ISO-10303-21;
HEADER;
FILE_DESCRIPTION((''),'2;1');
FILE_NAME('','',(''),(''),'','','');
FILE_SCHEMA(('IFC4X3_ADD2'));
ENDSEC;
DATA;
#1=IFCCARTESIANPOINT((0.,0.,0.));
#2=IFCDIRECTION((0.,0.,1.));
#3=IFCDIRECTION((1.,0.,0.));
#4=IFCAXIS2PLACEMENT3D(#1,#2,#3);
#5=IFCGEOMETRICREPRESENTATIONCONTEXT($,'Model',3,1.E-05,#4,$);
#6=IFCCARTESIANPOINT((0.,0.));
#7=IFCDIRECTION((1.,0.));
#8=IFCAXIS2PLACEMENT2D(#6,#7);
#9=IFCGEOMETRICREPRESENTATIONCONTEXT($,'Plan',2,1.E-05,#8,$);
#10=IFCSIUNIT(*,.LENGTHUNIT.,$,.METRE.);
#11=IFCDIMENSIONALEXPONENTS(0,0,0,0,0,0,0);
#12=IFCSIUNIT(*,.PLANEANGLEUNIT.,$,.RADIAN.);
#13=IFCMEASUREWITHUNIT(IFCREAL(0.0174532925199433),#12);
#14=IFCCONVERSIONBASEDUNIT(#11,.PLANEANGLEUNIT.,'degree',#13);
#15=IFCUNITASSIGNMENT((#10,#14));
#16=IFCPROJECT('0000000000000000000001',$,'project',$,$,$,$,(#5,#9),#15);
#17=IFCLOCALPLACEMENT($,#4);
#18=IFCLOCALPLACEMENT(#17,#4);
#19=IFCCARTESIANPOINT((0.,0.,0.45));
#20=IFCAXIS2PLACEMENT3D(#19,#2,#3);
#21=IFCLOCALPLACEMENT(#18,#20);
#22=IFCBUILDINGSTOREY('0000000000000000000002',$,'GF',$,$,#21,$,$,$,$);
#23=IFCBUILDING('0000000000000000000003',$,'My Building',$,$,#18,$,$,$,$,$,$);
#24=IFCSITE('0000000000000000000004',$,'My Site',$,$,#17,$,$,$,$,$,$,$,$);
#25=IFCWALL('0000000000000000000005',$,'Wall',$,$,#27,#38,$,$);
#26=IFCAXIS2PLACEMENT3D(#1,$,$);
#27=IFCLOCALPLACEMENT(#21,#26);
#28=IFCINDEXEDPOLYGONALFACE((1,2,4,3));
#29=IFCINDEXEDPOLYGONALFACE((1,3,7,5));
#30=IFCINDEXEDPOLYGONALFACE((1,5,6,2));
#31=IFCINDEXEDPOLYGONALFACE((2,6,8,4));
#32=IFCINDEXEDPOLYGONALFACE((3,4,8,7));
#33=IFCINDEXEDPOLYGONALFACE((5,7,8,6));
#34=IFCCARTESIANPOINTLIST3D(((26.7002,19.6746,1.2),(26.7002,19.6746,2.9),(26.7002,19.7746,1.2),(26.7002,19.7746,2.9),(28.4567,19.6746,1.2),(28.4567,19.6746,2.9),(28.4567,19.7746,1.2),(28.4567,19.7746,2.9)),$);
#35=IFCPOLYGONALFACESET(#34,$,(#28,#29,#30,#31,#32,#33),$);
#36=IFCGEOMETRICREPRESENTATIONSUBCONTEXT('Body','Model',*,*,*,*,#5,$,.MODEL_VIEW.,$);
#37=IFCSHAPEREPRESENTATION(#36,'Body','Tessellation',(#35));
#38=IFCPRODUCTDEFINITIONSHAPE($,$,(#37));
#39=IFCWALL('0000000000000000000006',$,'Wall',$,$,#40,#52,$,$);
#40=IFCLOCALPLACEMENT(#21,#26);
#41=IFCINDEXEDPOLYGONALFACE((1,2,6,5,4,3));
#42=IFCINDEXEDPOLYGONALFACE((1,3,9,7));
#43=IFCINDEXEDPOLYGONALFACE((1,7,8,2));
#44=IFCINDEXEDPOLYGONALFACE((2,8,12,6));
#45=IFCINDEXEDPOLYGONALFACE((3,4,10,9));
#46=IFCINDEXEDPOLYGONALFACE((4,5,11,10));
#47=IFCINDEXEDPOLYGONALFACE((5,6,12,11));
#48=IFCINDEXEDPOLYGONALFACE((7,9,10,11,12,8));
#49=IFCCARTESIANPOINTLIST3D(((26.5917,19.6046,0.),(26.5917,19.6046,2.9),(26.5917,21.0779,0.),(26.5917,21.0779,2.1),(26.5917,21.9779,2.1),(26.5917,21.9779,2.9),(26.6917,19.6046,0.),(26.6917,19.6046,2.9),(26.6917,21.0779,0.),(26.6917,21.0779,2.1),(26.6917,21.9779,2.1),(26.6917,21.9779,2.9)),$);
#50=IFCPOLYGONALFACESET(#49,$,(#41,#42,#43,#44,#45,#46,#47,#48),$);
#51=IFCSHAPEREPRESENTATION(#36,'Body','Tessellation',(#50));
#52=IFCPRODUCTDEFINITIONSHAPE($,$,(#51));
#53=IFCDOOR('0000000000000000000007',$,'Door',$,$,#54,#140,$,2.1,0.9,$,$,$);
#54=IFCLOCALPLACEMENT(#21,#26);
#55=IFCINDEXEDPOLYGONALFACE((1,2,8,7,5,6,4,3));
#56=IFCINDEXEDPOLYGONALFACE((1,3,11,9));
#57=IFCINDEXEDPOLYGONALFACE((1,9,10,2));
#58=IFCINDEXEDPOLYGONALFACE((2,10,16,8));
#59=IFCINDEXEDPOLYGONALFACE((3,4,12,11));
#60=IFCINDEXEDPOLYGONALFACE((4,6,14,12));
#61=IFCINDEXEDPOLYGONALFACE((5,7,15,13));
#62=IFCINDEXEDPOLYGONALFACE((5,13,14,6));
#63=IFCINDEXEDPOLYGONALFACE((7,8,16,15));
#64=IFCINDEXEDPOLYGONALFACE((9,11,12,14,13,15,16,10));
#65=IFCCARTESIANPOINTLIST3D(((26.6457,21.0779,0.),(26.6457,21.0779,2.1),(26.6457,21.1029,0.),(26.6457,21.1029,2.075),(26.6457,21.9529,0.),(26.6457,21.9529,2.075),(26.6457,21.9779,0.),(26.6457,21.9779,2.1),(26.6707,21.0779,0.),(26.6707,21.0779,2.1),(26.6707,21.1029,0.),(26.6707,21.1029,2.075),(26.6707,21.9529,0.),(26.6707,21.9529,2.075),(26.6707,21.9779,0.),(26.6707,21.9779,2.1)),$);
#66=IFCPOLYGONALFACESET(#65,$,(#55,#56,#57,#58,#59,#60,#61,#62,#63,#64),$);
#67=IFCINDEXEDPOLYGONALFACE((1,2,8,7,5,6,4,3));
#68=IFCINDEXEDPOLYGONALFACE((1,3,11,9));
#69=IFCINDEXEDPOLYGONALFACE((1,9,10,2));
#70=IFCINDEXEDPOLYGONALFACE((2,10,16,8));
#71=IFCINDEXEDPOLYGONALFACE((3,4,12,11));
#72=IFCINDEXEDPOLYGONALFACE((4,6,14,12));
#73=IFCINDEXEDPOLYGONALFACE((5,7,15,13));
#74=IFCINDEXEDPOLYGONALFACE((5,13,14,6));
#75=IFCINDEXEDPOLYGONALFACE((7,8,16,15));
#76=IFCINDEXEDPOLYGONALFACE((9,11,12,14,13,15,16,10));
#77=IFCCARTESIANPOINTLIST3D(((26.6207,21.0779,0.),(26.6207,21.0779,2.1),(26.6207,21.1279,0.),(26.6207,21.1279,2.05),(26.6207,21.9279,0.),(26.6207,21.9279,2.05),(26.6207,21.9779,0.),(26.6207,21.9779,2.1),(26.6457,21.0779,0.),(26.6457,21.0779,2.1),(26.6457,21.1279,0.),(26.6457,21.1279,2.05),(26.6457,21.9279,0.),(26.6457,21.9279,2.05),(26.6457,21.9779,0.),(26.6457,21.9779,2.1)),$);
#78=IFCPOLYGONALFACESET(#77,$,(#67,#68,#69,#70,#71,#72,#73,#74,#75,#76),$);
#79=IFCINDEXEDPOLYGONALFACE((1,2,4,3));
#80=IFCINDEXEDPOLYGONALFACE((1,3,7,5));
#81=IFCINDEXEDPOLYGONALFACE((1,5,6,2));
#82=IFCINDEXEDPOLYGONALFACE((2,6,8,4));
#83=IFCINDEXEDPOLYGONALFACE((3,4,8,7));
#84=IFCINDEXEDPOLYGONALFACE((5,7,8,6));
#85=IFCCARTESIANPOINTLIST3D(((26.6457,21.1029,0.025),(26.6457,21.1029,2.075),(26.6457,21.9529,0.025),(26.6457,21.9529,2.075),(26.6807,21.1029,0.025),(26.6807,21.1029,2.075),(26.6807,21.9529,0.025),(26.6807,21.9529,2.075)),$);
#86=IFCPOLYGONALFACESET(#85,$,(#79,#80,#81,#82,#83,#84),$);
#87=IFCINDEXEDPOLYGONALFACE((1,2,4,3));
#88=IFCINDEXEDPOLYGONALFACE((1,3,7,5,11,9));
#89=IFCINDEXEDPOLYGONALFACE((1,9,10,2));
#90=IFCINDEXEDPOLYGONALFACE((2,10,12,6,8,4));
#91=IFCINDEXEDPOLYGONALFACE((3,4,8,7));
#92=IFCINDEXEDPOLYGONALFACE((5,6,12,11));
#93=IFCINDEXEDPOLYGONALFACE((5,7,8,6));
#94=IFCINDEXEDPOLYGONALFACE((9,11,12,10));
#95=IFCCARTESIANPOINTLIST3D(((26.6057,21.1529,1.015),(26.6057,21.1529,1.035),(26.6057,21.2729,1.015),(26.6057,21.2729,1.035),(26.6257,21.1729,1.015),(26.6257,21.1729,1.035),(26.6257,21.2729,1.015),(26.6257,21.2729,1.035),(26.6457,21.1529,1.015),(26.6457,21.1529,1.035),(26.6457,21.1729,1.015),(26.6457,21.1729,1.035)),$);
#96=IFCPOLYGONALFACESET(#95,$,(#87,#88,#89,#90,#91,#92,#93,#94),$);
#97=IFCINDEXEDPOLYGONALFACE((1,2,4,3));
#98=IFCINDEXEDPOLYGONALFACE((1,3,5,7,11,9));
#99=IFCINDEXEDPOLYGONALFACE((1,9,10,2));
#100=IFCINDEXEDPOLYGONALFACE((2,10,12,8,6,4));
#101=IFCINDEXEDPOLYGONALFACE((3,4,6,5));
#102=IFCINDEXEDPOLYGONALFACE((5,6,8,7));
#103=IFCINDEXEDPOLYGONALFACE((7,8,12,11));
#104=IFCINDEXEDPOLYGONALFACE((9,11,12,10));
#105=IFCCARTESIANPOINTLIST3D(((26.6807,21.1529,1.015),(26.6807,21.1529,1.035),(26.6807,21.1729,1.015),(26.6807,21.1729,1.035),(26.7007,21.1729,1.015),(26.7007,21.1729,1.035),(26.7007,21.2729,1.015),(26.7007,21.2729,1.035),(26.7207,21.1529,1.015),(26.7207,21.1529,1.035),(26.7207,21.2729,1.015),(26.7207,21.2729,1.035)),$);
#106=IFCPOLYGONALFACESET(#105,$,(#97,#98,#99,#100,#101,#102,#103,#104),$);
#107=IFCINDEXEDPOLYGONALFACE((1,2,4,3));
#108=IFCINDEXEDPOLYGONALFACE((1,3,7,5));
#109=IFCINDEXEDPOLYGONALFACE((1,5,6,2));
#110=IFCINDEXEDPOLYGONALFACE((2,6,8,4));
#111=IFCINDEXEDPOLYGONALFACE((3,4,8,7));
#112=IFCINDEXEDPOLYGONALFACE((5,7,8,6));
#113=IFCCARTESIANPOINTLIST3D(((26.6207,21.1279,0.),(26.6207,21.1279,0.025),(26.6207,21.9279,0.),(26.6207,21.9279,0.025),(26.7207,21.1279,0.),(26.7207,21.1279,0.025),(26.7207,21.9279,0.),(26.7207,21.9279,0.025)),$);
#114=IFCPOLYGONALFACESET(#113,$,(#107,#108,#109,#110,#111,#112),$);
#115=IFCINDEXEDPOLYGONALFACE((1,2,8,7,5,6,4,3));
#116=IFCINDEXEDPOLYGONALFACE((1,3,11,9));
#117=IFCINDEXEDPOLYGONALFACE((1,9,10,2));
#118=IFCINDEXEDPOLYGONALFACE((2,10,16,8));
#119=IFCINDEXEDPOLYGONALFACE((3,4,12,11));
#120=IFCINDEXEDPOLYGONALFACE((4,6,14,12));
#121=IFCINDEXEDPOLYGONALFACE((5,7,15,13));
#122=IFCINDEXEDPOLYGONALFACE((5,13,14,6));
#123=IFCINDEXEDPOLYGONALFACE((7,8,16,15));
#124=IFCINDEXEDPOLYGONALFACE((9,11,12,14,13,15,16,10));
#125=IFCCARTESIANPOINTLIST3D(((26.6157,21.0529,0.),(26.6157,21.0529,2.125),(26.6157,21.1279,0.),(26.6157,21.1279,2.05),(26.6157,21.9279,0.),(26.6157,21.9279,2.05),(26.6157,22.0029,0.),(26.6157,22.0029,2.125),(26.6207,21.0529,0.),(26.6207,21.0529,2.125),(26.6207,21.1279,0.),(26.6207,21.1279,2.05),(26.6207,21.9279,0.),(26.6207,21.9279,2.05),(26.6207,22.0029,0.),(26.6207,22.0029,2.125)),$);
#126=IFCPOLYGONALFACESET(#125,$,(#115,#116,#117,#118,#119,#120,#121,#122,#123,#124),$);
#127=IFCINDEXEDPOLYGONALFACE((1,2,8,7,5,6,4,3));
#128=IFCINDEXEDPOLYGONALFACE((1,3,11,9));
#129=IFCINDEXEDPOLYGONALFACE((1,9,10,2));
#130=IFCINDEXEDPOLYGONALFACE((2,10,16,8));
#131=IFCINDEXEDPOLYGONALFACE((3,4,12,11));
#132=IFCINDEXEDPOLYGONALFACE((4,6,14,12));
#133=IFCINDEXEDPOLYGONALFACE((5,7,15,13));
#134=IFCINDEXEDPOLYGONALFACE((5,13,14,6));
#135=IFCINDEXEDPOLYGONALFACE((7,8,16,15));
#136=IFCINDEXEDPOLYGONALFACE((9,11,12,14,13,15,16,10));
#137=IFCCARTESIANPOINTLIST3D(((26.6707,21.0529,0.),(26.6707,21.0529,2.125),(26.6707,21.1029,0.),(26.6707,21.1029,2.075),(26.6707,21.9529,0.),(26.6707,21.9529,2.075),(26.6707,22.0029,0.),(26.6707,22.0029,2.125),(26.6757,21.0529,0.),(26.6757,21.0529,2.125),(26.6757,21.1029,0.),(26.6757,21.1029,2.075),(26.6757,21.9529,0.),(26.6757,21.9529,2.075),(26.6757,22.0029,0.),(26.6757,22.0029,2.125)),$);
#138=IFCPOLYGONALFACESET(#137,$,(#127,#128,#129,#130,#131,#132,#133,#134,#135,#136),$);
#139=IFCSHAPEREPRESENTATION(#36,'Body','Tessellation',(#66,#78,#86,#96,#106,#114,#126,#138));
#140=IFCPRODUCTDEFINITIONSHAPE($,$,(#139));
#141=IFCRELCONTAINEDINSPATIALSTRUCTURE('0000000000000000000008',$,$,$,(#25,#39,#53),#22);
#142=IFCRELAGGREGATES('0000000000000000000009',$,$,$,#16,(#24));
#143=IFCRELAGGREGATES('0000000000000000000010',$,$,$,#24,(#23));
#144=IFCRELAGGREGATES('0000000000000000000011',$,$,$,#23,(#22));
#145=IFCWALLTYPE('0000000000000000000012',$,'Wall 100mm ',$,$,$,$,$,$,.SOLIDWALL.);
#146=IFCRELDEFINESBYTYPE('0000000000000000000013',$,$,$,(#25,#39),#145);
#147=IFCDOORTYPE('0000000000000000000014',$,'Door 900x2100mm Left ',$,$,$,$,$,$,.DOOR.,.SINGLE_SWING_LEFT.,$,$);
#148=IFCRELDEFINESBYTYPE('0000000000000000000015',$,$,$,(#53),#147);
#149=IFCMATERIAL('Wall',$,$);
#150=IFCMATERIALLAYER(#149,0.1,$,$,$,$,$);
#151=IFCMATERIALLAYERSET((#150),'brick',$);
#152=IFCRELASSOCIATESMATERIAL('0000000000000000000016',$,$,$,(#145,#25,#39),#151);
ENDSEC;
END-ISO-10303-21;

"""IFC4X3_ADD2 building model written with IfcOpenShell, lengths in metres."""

from ifc_helpers import new_model, entity, si_unit, converted_unit, frame, origin_with_axes, origin_2d_with_axis, place, context, subcontext, project, spatial, line, indexed_curve, outline, extrude, shape, source, transform, mapped, material, layer, layer_set, layer_usage, type_object, type_shapes, element, fill, save


model = new_model("IFC4X3_ADD2")

# Units and contexts
model_context = context("Model", 3, precision=1e-05, world=origin_with_axes())
plan_context = context("Plan", 2, precision=1e-05, world=origin_2d_with_axis())
body_context_1 = subcontext(model_context, "Body", "Model", "MODEL_VIEW")
body_context_2 = subcontext(plan_context, "Body", "Plan", "PLAN_VIEW")
ifc_project = project(units=[si_unit("LENGTHUNIT", "METRE"), converted_unit("PLANEANGLEUNIT", "degree", entity("IfcReal", 0.0174532925199433), si_unit("PLANEANGLEUNIT", "RADIAN"), dimensions=[0, 0, 0, 0, 0, 0, 0])], contexts=[model_context, plan_context])

# Site, building, storey
site_placement = place(None, origin_with_axes())
site = spatial("IfcSite", under=ifc_project, at=site_placement, Name="My Site")
building_placement = place(site_placement, origin_with_axes())
building = spatial("IfcBuilding", under=site, at=building_placement, Name="My Building")
storey_placement = place(building_placement, frame((0.0, 0.0, 0.45), z_axis=(0.0, 0.0, 1.0), x_axis=(1.0, 0.0, 0.0)))
storey = spatial("IfcBuildingStorey", under=building, at=storey_placement, Name="GF")

# Shared definitions
ifc_material_1 = material(Name="Wall")

# Shared definitions
ifc_layer_1 = layer(ifc_material_1, 0.1)
ifc_layer_set_1 = layer_set([ifc_layer_1], Name="brick")
wall_type_1 = type_object("IfcWallType", Name="Wall 100mm ", PredefinedType="SOLIDWALL", material=ifc_layer_set_1)

# Wall
ifc_layer_usage_1 = layer_usage(ifc_layer_set_1, "AXIS2", "POSITIVE", 0.0)
wall_1_placement = place(storey_placement, frame((26.7002, 19.6746, 1.2), z_axis=(0.0, 0.0, 1.0), x_axis=(1.0, 0.0, 0.0)))
element("IfcWall", 1, at=wall_1_placement, inside=storey, type_object=wall_type_1, material=ifc_layer_usage_1, Name="Wall", context=body_context_1, shape_type="SweptSolid", body=[
    extrude(outline(indexed_curve([(0.0, 0.0), (0.0, 0.1), (1.7565, 0.1), (1.7565, 0.0), (0.0, 0.0)], self_intersect=False)), origin_with_axes(), (0.0, 0.0, 1.0), 1.7),
])

# Wall, opening, door
ifc_layer_usage_2 = layer_usage(ifc_layer_set_1, "AXIS2", "POSITIVE", 0.0)
wall_2_placement = place(storey_placement, frame((26.6917, 19.6046, 0.0), z_axis=(0.0, 0.0, 1.0), x_axis=(0.0, 1.0, 0.0)))
wall_2 = element("IfcWall", 2, at=wall_2_placement, inside=storey, type_object=wall_type_1, material=ifc_layer_usage_2, Name="Wall", context=body_context_1, shape_type="SweptSolid", body=[
    extrude(outline(indexed_curve([(0.0, 0.0), (0.0, 0.1), (2.3733, 0.1), (2.3733, 0.0), (0.0, 0.0)], self_intersect=False)), origin_with_axes(), (0.0, 0.0, 1.0), 2.9),
])
shared_shape_1 = source(origin_with_axes(), body_context_1, "Body", "SweptSolid", [
    extrude(outline(indexed_curve([(0.0, 0.0), (0.9, 0.0), (0.9, 2.1), (0.0, 2.1)], segments=[line(1, 2, 3, 4, 1)])), frame((0.0, -0.6, 0.0), z_axis=(0.0, -1.0, 0.0), x_axis=(1.0, 0.0, 0.0)), (0.0, 0.0, -1.0), 1.2),
])
opening_1_placement = place(wall_2_placement, frame((2.3733, 0.071, 0.0), z_axis=(0.0, 0.0, 1.0), x_axis=(-1.0, 0.0, 0.0)))
opening_1 = element("IfcOpeningElement", 3, at=opening_1_placement, cuts=wall_2, PredefinedType="OPENING", context=body_context_1, shape_type="MappedRepresentation", body=[
    mapped(shared_shape_1, transform((0.0, 0.0, 0.0), x_axis=(1.0, 0.0, 0.0), y_axis=(0.0, 1.0, 0.0), z_axis=(0.0, 0.0, 1.0), scale=1.0)),
])
door_type_1 = type_object("IfcDoorType", Name="Door 900x2100mm Left ", OperationType="SINGLE_SWING_LEFT", PredefinedType="DOOR")
shared_shape_2 = source(origin_with_axes(), body_context_1, "Body", "SweptSolid", [
    extrude(outline(indexed_curve([(0.0, 0.0), (0.0, 2.1), (0.9, 2.1), (0.9, 0.0), (0.875, 0.0), (0.875, 2.075), (0.025, 2.075), (0.025, 0.0)], segments=[line(1, 2, 3, 4, 5, 6, 7, 8, 1)])), frame((0.0, 0.025, 0.0), z_axis=(0.0, -1.0, 0.0), x_axis=(1.0, 0.0, 0.0)), (0.0, 0.0, -1.0), 0.025),
    extrude(outline(indexed_curve([(0.0, 0.0), (0.0, 2.1), (0.9, 2.1), (0.9, 0.0), (0.85, 0.0), (0.85, 2.05), (0.05, 2.05), (0.05, 0.0)], segments=[line(1, 2, 3, 4, 5, 6, 7, 8, 1)])), frame((0.0, 0.0, 0.0), z_axis=(0.0, -1.0, 0.0), x_axis=(1.0, 0.0, 0.0)), (0.0, 0.0, -1.0), 0.025),
    extrude(outline(indexed_curve([(0.0, 0.0), (0.85, 0.0), (0.85, 0.035), (0.0, 0.035)], segments=[line(1, 2, 3, 4, 1)])), frame((0.025, 0.025, 0.025), z_axis=(0.0, 0.0, 1.0), x_axis=(1.0, 0.0, 0.0)), (0.0, 0.0, 1.0), 2.05),
    extrude(outline(indexed_curve([(0.0, 0.0), (0.0, -0.04), (-0.12, -0.04), (-0.12, -0.02), (-0.02, -0.02), (-0.02, 0.0)], segments=[line(1, 2, 3, 4, 5, 6, 1)])), frame((0.825, 0.025, 1.015), z_axis=(0.0, 0.0, 1.0), x_axis=(1.0, 0.0, 0.0)), (0.0, 0.0, 1.0), 0.02),
    extrude(outline(indexed_curve([(0.0, 0.0), (0.0, 0.04), (-0.12, 0.04), (-0.12, 0.02), (-0.02, 0.02), (-0.02, 0.0)], segments=[line(1, 2, 3, 4, 5, 6, 1)])), frame((0.825, 0.06, 1.015), z_axis=(0.0, 0.0, 1.0), x_axis=(1.0, 0.0, 0.0)), (0.0, 0.0, 1.0), 0.02),
    extrude(outline(indexed_curve([(0.0, 0.0), (0.8, 0.0), (0.8, 0.1), (0.0, 0.1)], segments=[line(1, 2, 3, 4, 1)])), frame((0.05, 0.0, 0.0), z_axis=(0.0, 0.0, 1.0), x_axis=(1.0, 0.0, 0.0)), (0.0, 0.0, 1.0), 0.025),
    extrude(outline(indexed_curve([(0.0, 0.0), (0.0, 2.125), (0.95, 2.125), (0.95, 0.0), (0.875, 0.0), (0.875, 2.05), (0.075, 2.05), (0.075, 0.0)], segments=[line(1, 2, 3, 4, 5, 6, 7, 8, 1)])), frame((-0.025, -0.005, 0.0), z_axis=(0.0, -1.0, 0.0), x_axis=(1.0, 0.0, 0.0)), (0.0, 0.0, -1.0), 0.005),
    extrude(outline(indexed_curve([(0.0, 0.0), (0.0, 2.125), (0.95, 2.125), (0.95, 0.0), (0.9, 0.0), (0.9, 2.075), (0.05, 2.075), (0.05, 0.0)], segments=[line(1, 2, 3, 4, 5, 6, 7, 8, 1)])), frame((-0.025, 0.05, 0.0), z_axis=(0.0, -1.0, 0.0), x_axis=(1.0, 0.0, 0.0)), (0.0, 0.0, -1.0), 0.005),
])
shared_shape_3 = source(origin_with_axes(), body_context_2, "Body", "Curve2D", [
    entity("IfcIndexedPolyCurve", entity("IfcCartesianPointList2D", [[0.0, 0.0], [0.0, 0.05], [0.025, 0.05], [0.025, 0.025], [0.05, 0.025], [0.05, 0.0]]), [entity("IfcLineIndex", [1, 2, 3, 4, 5, 6, 1])]),
    entity("IfcIndexedPolyCurve", entity("IfcCartesianPointList2D", [[0.9, 0.0], [0.9, 0.05], [0.875, 0.05], [0.875, 0.025], [0.85, 0.025], [0.85, 0.0]]), [entity("IfcLineIndex", [1, 2, 3, 4, 5, 6, 1])]),
    entity("IfcTrimmedCurve", entity("IfcEllipse", entity("IfcAxis2Placement2D", entity("IfcCartesianPoint", [0.06, 0.05]), entity("IfcDirection", [1.0, 0.0])), 0.815, 0.85), [entity("IfcCartesianPoint", [0.875, 0.05])], [entity("IfcCartesianPoint", [0.06, 0.9])], True, "CARTESIAN"),
    entity("IfcIndexedPolyCurve", entity("IfcCartesianPointList2D", [[0.025, 0.05], [0.06, 0.05], [0.06, 0.9], [0.025, 0.9]]), [entity("IfcLineIndex", [1, 2, 3, 4, 1])]),
])
type_shapes(door_type_1, [shared_shape_2, shared_shape_3])
door_1_placement = place(opening_1_placement, frame((0.0, 0.0, 0.0), z_axis=(0.0, 0.0, 1.0), x_axis=(1.0, 0.0, 0.0)))
door_1 = element("IfcDoor", 4, at=door_1_placement, inside=storey, type_object=door_type_1, Name="Door", OverallHeight=2.1, OverallWidth=0.9, shapes=[
    shape(body_context_1, "Body", "MappedRepresentation", [mapped(shared_shape_2, transform((0.0, 0.0, 0.0), x_axis=(1.0, 0.0, 0.0), y_axis=(0.0, 1.0, 0.0), z_axis=(0.0, 0.0, 1.0), scale=1.0))]),
    shape(body_context_2, "Body", "MappedRepresentation", [mapped(shared_shape_3, transform((0.0, 0.0, 0.0), x_axis=(1.0, 0.0, 0.0), y_axis=(0.0, 1.0, 0.0), z_axis=(0.0, 0.0, 1.0), scale=1.0))]),
])
fill(opening_1, door_1)

save(model, "model.ifc")
